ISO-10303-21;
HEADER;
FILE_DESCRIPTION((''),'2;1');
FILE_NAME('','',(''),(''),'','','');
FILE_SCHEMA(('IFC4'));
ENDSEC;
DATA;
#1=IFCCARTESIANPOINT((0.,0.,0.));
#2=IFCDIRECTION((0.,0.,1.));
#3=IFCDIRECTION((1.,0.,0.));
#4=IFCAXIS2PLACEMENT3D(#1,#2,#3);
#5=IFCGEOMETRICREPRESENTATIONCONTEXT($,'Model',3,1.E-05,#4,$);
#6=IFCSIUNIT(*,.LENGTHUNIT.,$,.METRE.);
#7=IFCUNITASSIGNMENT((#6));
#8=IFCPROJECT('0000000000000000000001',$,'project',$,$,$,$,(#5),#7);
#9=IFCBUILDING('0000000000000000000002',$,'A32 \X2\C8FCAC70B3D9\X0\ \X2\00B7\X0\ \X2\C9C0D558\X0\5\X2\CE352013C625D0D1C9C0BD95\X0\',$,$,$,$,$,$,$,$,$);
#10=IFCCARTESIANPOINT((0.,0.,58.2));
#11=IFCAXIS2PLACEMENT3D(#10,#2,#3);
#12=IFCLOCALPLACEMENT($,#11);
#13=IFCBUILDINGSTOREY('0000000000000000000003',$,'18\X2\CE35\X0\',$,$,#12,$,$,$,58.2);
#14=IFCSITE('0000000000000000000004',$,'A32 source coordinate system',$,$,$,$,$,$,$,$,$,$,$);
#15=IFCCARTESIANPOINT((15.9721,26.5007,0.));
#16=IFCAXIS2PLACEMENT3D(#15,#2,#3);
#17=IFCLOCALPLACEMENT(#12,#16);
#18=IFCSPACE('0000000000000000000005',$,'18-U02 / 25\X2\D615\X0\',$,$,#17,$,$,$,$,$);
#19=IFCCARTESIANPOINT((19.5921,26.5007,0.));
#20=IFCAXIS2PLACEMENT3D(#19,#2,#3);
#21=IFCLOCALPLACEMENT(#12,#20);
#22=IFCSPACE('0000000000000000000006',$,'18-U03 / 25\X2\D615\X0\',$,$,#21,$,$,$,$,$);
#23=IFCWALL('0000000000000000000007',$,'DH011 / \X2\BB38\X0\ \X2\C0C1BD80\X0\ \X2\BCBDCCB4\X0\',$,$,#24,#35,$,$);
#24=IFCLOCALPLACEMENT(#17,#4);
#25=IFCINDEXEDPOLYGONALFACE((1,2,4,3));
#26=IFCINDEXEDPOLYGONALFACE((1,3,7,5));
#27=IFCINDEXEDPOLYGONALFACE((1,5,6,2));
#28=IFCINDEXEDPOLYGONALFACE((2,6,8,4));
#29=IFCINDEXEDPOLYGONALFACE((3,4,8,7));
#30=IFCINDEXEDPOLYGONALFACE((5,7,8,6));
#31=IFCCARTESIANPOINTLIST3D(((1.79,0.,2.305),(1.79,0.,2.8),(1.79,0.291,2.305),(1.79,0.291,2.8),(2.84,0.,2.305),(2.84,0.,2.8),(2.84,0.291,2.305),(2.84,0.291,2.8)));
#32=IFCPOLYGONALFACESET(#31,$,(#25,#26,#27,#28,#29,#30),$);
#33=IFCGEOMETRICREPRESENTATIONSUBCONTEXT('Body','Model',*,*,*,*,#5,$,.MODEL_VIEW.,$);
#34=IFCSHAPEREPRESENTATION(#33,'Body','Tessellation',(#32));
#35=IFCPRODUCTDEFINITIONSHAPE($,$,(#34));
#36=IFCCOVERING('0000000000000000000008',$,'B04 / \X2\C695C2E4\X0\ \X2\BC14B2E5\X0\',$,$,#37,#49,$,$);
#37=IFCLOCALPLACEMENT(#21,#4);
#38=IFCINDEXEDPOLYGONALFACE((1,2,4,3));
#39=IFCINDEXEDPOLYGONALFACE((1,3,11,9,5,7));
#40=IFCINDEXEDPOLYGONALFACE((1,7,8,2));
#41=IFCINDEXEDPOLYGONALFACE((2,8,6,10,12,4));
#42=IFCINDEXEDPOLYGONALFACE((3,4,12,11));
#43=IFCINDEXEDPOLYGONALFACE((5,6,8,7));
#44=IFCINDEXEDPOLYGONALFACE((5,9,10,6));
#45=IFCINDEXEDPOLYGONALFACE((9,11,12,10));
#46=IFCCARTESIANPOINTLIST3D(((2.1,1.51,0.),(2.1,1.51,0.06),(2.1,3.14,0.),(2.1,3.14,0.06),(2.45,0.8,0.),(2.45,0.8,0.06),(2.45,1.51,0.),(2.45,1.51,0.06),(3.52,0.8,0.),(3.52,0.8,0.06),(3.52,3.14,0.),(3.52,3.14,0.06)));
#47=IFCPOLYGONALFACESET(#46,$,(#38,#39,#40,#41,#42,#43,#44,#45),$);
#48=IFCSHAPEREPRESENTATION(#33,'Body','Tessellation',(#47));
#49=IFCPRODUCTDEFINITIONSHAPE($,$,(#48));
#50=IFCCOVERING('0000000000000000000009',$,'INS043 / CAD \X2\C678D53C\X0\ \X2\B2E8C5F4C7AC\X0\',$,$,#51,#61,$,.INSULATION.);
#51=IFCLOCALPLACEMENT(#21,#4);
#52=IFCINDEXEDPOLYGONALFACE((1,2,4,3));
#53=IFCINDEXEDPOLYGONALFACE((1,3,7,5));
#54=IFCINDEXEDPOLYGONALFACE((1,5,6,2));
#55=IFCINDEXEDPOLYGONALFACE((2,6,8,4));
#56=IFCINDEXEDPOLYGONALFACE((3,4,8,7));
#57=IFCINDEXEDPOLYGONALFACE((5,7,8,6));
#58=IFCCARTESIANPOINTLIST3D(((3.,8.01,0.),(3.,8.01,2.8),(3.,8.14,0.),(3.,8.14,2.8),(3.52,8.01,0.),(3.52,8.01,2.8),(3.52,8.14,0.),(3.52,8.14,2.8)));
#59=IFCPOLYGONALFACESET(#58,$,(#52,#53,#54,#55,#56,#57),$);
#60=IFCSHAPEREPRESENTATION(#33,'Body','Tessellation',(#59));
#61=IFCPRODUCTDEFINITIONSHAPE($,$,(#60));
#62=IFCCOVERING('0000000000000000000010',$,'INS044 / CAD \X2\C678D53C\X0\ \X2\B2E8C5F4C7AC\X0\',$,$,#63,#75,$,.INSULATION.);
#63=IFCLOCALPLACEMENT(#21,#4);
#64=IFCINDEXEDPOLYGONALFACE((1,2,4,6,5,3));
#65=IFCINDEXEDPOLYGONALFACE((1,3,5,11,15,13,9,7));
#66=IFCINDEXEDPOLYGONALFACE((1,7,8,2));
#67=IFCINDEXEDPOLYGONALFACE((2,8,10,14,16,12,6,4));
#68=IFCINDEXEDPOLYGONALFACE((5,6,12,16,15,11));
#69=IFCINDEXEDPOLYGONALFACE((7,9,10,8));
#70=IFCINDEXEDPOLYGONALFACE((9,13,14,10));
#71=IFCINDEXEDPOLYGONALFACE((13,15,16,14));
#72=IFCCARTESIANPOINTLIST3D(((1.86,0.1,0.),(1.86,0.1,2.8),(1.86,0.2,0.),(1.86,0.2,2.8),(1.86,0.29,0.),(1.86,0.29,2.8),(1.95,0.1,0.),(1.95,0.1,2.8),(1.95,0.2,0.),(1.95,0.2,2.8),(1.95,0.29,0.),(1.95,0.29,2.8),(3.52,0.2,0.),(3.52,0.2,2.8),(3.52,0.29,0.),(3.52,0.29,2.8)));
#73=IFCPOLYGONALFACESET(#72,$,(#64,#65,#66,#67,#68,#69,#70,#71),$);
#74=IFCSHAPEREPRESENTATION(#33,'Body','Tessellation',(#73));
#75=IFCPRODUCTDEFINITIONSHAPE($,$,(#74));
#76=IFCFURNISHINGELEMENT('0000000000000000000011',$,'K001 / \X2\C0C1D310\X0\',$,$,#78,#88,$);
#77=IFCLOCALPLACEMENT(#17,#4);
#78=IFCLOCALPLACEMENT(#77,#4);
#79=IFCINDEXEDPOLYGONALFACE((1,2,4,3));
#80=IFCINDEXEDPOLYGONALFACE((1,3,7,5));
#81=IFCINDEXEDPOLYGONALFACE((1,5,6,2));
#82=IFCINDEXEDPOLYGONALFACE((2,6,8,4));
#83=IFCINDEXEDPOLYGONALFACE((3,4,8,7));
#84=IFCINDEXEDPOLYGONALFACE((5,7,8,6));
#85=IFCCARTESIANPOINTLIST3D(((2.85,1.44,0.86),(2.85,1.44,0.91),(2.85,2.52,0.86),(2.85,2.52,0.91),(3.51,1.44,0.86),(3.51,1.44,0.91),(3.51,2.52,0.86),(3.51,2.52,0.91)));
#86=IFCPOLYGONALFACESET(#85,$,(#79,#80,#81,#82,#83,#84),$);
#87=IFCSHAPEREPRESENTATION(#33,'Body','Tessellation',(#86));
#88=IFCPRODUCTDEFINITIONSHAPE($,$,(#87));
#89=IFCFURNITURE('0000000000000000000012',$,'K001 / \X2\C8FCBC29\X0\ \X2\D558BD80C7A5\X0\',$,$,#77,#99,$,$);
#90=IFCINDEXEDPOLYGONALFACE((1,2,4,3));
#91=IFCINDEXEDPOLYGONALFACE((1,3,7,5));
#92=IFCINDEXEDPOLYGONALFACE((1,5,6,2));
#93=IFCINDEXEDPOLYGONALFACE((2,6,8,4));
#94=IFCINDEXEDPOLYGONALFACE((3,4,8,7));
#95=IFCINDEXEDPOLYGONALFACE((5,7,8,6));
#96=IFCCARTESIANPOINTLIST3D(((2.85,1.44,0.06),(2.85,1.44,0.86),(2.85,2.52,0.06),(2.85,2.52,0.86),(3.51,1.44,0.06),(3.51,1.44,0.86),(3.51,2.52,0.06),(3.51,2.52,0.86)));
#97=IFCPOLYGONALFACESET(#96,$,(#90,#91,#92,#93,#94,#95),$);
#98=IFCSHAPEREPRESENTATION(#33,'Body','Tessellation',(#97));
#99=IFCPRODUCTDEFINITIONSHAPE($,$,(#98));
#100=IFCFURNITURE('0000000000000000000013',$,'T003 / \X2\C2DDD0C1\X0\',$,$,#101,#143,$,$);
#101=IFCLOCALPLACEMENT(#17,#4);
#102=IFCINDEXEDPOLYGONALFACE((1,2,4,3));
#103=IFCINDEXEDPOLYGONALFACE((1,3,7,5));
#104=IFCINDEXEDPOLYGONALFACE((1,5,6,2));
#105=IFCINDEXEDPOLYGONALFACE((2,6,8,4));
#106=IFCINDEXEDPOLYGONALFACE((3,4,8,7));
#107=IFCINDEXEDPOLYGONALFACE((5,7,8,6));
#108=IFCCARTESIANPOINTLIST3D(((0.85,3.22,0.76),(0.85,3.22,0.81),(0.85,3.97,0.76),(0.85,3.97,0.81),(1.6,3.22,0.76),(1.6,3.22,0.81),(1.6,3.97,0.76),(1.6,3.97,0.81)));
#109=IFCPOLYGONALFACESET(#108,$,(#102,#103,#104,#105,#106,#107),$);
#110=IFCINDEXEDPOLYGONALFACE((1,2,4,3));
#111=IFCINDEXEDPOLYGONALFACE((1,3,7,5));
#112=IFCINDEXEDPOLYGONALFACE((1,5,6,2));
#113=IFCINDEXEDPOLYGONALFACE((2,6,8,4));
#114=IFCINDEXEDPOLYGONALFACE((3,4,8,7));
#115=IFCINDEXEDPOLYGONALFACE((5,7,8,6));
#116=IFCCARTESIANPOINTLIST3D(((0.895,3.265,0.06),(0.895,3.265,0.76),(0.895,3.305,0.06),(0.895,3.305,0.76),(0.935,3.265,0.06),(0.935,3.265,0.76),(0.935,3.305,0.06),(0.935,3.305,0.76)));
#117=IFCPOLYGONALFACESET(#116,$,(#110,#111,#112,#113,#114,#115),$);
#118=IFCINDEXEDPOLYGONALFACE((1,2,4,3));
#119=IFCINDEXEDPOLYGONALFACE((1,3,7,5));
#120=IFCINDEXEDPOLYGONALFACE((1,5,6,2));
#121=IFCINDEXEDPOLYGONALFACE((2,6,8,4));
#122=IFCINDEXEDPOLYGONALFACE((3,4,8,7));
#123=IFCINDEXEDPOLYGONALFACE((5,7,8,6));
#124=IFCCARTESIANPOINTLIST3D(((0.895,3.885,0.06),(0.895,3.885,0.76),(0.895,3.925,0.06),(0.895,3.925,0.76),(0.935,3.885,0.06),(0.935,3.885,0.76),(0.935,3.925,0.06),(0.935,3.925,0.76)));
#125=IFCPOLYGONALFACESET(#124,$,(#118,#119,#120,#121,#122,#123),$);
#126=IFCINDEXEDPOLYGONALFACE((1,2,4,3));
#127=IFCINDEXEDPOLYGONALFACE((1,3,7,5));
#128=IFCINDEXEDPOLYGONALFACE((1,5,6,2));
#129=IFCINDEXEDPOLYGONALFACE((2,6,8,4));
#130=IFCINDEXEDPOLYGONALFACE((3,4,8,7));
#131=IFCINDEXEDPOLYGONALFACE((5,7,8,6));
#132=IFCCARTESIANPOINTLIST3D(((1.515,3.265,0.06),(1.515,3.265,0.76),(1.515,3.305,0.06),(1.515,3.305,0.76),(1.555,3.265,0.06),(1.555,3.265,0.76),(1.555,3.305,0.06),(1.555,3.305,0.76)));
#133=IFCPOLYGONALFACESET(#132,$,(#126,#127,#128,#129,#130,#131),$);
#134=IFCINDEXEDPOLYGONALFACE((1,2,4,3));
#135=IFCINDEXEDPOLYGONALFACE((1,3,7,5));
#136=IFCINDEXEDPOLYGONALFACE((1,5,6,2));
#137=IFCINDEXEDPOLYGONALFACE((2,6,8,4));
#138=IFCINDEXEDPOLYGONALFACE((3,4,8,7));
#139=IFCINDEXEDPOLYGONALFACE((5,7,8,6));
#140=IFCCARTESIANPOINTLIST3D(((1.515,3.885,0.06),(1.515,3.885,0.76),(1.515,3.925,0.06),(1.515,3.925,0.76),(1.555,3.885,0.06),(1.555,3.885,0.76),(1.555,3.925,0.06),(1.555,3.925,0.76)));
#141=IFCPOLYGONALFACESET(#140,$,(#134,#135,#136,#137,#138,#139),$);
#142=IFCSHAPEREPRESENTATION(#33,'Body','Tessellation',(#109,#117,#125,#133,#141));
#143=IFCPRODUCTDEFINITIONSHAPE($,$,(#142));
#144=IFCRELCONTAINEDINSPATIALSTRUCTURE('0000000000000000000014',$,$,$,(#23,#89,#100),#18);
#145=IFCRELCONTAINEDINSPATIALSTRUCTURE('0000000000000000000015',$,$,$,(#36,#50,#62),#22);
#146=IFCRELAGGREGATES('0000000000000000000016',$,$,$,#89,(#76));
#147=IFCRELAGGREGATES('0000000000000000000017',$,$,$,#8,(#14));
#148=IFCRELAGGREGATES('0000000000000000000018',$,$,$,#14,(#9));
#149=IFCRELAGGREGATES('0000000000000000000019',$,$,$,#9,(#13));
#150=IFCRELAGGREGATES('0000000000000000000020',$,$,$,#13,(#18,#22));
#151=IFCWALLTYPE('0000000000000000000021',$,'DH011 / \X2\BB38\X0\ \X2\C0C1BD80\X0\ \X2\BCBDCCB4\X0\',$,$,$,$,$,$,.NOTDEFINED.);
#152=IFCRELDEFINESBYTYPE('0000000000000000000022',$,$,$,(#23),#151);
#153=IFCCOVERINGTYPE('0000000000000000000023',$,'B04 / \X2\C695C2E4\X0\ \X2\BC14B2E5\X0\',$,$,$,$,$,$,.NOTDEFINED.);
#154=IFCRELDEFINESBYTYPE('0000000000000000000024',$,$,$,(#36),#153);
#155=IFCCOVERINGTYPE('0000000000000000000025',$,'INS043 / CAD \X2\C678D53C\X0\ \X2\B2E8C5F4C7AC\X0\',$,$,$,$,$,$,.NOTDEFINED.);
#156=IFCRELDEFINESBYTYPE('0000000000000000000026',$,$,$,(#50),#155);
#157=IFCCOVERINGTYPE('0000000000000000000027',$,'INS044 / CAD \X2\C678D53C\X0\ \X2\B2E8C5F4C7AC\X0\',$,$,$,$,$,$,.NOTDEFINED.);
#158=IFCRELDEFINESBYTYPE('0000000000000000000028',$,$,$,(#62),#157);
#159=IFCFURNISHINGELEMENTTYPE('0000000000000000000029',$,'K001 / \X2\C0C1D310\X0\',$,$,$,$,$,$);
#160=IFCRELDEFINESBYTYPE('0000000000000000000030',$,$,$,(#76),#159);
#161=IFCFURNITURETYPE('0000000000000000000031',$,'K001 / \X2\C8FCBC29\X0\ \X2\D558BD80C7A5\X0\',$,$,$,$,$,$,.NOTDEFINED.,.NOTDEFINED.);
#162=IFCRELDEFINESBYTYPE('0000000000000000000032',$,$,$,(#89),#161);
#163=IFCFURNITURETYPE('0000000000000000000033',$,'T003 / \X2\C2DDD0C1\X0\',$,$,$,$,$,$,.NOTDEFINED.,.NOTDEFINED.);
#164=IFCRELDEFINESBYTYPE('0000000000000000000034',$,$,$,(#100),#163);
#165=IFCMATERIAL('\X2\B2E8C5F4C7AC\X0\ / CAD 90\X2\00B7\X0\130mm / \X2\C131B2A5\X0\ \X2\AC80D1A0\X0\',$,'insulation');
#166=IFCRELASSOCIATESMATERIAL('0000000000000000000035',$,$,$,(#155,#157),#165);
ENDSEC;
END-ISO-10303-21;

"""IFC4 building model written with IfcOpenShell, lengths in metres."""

from ifc_helpers import new_model, si_unit, frame, origin, origin_with_axes, place, context, subcontext, project, spatial, polyline, outline, extrude, source, transform, mapped, material, type_object, type_shapes, element, aggregate, save


model = new_model("IFC4")

# Units and contexts
model_context = context("Model", 3, precision=1e-05, world=origin_with_axes())
body_context = subcontext(model_context, "Body", "Model", "MODEL_VIEW")
ifc_project = project(units=[si_unit("LENGTHUNIT", "METRE")], contexts=[model_context])

# Site, building, storey, space
site = spatial("IfcSite", under=ifc_project, Name="A32 source coordinate system")
building = spatial("IfcBuilding", under=site, Name="A32 주거동 · 지하5층–옥탑지붕")
storey_placement = place(None, frame((0.0, 0.0, 58.2), z_axis=(0.0, 0.0, 1.0), x_axis=(1.0, 0.0, 0.0)))
storey = spatial("IfcBuildingStorey", under=building, at=storey_placement, Name="18층", Elevation=58.2)
space_1_placement = place(storey_placement, frame((15.9721, 26.5007, 0.0), z_axis=(0.0, 0.0, 1.0), x_axis=(1.0, 0.0, 0.0)))
space_1 = spatial("IfcSpace", under=storey, at=space_1_placement, Name="18-U02 / 25형")

# Wall
wall_type_1 = type_object("IfcWallType", Name="DH011 / 문 상부 벽체", PredefinedType="NOTDEFINED")
shared_shape_1 = source(origin(), body_context, "Body", "SweptSolid", [
    extrude(outline(polyline([(2.84, 0.0), (1.79, 0.0), (1.79, 0.291), (2.84, 0.291), (2.84, 0.0)])), frame((0.0, 0.0, 2.305)), (0.0, 0.0, 1.0), 0.495),
])
type_shapes(wall_type_1, [shared_shape_1])
wall_1_placement = place(space_1_placement, origin_with_axes())
element("IfcWall", 1, at=wall_1_placement, inside=space_1, type_object=wall_type_1, Name="DH011 / 문 상부 벽체", context=body_context, shape_type="MappedRepresentation", body=[
    mapped(shared_shape_1, transform((0.0, 0.0, 0.0), scale=1.0)),
])

# Shared definitions
space_2_placement = place(storey_placement, frame((19.5921, 26.5007, 0.0), z_axis=(0.0, 0.0, 1.0), x_axis=(1.0, 0.0, 0.0)))
space_2 = spatial("IfcSpace", under=storey, at=space_2_placement, Name="18-U03 / 25형")

# Coverings
covering_type_1 = type_object("IfcCoveringType", Name="B04 / 욕실 바닥", PredefinedType="NOTDEFINED")
shared_shape_2 = source(origin(), body_context, "Body", "SweptSolid", [
    extrude(outline(polyline([(2.1, 1.51), (2.1, 3.14), (3.52, 3.14), (3.52, 0.8), (2.45, 0.8), (2.45, 1.51), (2.1, 1.51)])), origin(), (0.0, 0.0, 1.0), 0.06),
])
type_shapes(covering_type_1, [shared_shape_2])
covering_1_placement = place(space_2_placement, origin_with_axes())
element("IfcCovering", 2, at=covering_1_placement, inside=space_2, type_object=covering_type_1, Name="B04 / 욕실 바닥", context=body_context, shape_type="MappedRepresentation", body=[
    mapped(shared_shape_2, transform((0.0, 0.0, 0.0), scale=1.0)),
])
ifc_material = material(Name="단열재 / CAD 90·130mm / 성능 검토", Category="insulation")
covering_type_2 = type_object("IfcCoveringType", Name="INS043 / CAD 외피 단열재", PredefinedType="NOTDEFINED", material=ifc_material)
shared_shape_3 = source(origin(), body_context, "Body", "SweptSolid", [
    extrude(outline(polyline([(3.52, 8.14), (3.52, 8.01), (3.0, 8.01), (3.0, 8.14), (3.52, 8.14)])), origin(), (0.0, 0.0, 1.0), 2.8),
])
type_shapes(covering_type_2, [shared_shape_3])
covering_2_placement = place(space_2_placement, origin_with_axes())
element("IfcCovering", 3, at=covering_2_placement, inside=space_2, type_object=covering_type_2, Name="INS043 / CAD 외피 단열재", PredefinedType="INSULATION", context=body_context, shape_type="MappedRepresentation", body=[
    mapped(shared_shape_3, transform((0.0, 0.0, 0.0), scale=1.0)),
])
covering_type_3 = type_object("IfcCoveringType", Name="INS044 / CAD 외피 단열재", PredefinedType="NOTDEFINED", material=ifc_material)
shared_shape_4 = source(origin(), body_context, "Body", "SweptSolid", [
    extrude(outline(polyline([(1.86, 0.2), (1.86, 0.29), (1.95, 0.29), (3.52, 0.29), (3.52, 0.2), (1.95, 0.2), (1.95, 0.1), (1.86, 0.1), (1.86, 0.2)])), origin(), (0.0, 0.0, 1.0), 2.8),
])
type_shapes(covering_type_3, [shared_shape_4])
covering_3_placement = place(space_2_placement, origin_with_axes())
element("IfcCovering", 4, at=covering_3_placement, inside=space_2, type_object=covering_type_3, Name="INS044 / CAD 외피 단열재", PredefinedType="INSULATION", context=body_context, shape_type="MappedRepresentation", body=[
    mapped(shared_shape_4, transform((0.0, 0.0, 0.0), scale=1.0)),
])

# Furnishing element
furnishing_element_type_1 = type_object("IfcFurnishingElementType", Name="K001 / 상판")
shared_shape_5 = source(origin(), body_context, "Body", "SweptSolid", [
    extrude(outline(polyline([(2.85, 2.52), (3.51, 2.52), (3.51, 1.44), (2.85, 1.44), (2.85, 2.52)])), frame((0.0, 0.0, 0.86)), (0.0, 0.0, 1.0), 0.05),
])
type_shapes(furnishing_element_type_1, [shared_shape_5])
furniture_1_placement = place(space_1_placement, origin_with_axes())
furnishing_1_placement = place(furniture_1_placement, origin_with_axes())
furnishing_1 = element("IfcFurnishingElement", 5, at=furnishing_1_placement, type_object=furnishing_element_type_1, Name="K001 / 상판", context=body_context, shape_type="MappedRepresentation", body=[
    mapped(shared_shape_5, transform((0.0, 0.0, 0.0), scale=1.0)),
])

# Furniture
furniture_type_1 = type_object("IfcFurnitureType", Name="K001 / 주방 하부장", AssemblyPlace="NOTDEFINED", PredefinedType="NOTDEFINED")
shared_shape_6 = source(origin(), body_context, "Body", "SweptSolid", [
    extrude(outline(polyline([(2.85, 1.44), (2.85, 2.52), (3.51, 2.52), (3.51, 1.44), (2.85, 1.44)])), frame((0.0, 0.0, 0.06)), (0.0, 0.0, 1.0), 0.8),
])
type_shapes(furniture_type_1, [shared_shape_6])
furniture_1 = element("IfcFurniture", 6, at=furniture_1_placement, inside=space_1, type_object=furniture_type_1, Name="K001 / 주방 하부장", context=body_context, shape_type="MappedRepresentation", body=[
    mapped(shared_shape_6, transform((0.0, 0.0, 0.0), scale=1.0)),
])
aggregate(furniture_1, [furnishing_1])
furniture_type_2 = type_object("IfcFurnitureType", Name="T003 / 식탁", AssemblyPlace="NOTDEFINED", PredefinedType="NOTDEFINED")
shared_shape_7 = source(origin(), body_context, "Body", "SweptSolid", [
    extrude(outline(polyline([(1.6, 3.97), (1.6, 3.22), (0.85, 3.22), (0.85, 3.97), (1.6, 3.97)])), frame((0.0, 0.0, 0.76)), (0.0, 0.0, 1.0), 0.05),
    extrude(outline(polyline([(0.895, 3.265), (0.895, 3.305), (0.935, 3.305), (0.935, 3.265), (0.895, 3.265)])), frame((0.0, 0.0, 0.06)), (0.0, 0.0, 1.0), 0.7),
    extrude(outline(polyline([(0.895, 3.885), (0.895, 3.925), (0.935, 3.925), (0.935, 3.885), (0.895, 3.885)])), frame((0.0, 0.0, 0.06)), (0.0, 0.0, 1.0), 0.7),
    extrude(outline(polyline([(1.515, 3.265), (1.515, 3.305), (1.555, 3.305), (1.555, 3.265), (1.515, 3.265)])), frame((0.0, 0.0, 0.06)), (0.0, 0.0, 1.0), 0.7),
    extrude(outline(polyline([(1.515, 3.885), (1.515, 3.925), (1.555, 3.925), (1.555, 3.885), (1.515, 3.885)])), frame((0.0, 0.0, 0.06)), (0.0, 0.0, 1.0), 0.7),
])
type_shapes(furniture_type_2, [shared_shape_7])
furniture_2_placement = place(space_1_placement, origin_with_axes())
element("IfcFurniture", 7, at=furniture_2_placement, inside=space_1, type_object=furniture_type_2, Name="T003 / 식탁", context=body_context, shape_type="MappedRepresentation", body=[
    mapped(shared_shape_7, transform((0.0, 0.0, 0.0), scale=1.0)),
])

save(model, "model.ifc")
